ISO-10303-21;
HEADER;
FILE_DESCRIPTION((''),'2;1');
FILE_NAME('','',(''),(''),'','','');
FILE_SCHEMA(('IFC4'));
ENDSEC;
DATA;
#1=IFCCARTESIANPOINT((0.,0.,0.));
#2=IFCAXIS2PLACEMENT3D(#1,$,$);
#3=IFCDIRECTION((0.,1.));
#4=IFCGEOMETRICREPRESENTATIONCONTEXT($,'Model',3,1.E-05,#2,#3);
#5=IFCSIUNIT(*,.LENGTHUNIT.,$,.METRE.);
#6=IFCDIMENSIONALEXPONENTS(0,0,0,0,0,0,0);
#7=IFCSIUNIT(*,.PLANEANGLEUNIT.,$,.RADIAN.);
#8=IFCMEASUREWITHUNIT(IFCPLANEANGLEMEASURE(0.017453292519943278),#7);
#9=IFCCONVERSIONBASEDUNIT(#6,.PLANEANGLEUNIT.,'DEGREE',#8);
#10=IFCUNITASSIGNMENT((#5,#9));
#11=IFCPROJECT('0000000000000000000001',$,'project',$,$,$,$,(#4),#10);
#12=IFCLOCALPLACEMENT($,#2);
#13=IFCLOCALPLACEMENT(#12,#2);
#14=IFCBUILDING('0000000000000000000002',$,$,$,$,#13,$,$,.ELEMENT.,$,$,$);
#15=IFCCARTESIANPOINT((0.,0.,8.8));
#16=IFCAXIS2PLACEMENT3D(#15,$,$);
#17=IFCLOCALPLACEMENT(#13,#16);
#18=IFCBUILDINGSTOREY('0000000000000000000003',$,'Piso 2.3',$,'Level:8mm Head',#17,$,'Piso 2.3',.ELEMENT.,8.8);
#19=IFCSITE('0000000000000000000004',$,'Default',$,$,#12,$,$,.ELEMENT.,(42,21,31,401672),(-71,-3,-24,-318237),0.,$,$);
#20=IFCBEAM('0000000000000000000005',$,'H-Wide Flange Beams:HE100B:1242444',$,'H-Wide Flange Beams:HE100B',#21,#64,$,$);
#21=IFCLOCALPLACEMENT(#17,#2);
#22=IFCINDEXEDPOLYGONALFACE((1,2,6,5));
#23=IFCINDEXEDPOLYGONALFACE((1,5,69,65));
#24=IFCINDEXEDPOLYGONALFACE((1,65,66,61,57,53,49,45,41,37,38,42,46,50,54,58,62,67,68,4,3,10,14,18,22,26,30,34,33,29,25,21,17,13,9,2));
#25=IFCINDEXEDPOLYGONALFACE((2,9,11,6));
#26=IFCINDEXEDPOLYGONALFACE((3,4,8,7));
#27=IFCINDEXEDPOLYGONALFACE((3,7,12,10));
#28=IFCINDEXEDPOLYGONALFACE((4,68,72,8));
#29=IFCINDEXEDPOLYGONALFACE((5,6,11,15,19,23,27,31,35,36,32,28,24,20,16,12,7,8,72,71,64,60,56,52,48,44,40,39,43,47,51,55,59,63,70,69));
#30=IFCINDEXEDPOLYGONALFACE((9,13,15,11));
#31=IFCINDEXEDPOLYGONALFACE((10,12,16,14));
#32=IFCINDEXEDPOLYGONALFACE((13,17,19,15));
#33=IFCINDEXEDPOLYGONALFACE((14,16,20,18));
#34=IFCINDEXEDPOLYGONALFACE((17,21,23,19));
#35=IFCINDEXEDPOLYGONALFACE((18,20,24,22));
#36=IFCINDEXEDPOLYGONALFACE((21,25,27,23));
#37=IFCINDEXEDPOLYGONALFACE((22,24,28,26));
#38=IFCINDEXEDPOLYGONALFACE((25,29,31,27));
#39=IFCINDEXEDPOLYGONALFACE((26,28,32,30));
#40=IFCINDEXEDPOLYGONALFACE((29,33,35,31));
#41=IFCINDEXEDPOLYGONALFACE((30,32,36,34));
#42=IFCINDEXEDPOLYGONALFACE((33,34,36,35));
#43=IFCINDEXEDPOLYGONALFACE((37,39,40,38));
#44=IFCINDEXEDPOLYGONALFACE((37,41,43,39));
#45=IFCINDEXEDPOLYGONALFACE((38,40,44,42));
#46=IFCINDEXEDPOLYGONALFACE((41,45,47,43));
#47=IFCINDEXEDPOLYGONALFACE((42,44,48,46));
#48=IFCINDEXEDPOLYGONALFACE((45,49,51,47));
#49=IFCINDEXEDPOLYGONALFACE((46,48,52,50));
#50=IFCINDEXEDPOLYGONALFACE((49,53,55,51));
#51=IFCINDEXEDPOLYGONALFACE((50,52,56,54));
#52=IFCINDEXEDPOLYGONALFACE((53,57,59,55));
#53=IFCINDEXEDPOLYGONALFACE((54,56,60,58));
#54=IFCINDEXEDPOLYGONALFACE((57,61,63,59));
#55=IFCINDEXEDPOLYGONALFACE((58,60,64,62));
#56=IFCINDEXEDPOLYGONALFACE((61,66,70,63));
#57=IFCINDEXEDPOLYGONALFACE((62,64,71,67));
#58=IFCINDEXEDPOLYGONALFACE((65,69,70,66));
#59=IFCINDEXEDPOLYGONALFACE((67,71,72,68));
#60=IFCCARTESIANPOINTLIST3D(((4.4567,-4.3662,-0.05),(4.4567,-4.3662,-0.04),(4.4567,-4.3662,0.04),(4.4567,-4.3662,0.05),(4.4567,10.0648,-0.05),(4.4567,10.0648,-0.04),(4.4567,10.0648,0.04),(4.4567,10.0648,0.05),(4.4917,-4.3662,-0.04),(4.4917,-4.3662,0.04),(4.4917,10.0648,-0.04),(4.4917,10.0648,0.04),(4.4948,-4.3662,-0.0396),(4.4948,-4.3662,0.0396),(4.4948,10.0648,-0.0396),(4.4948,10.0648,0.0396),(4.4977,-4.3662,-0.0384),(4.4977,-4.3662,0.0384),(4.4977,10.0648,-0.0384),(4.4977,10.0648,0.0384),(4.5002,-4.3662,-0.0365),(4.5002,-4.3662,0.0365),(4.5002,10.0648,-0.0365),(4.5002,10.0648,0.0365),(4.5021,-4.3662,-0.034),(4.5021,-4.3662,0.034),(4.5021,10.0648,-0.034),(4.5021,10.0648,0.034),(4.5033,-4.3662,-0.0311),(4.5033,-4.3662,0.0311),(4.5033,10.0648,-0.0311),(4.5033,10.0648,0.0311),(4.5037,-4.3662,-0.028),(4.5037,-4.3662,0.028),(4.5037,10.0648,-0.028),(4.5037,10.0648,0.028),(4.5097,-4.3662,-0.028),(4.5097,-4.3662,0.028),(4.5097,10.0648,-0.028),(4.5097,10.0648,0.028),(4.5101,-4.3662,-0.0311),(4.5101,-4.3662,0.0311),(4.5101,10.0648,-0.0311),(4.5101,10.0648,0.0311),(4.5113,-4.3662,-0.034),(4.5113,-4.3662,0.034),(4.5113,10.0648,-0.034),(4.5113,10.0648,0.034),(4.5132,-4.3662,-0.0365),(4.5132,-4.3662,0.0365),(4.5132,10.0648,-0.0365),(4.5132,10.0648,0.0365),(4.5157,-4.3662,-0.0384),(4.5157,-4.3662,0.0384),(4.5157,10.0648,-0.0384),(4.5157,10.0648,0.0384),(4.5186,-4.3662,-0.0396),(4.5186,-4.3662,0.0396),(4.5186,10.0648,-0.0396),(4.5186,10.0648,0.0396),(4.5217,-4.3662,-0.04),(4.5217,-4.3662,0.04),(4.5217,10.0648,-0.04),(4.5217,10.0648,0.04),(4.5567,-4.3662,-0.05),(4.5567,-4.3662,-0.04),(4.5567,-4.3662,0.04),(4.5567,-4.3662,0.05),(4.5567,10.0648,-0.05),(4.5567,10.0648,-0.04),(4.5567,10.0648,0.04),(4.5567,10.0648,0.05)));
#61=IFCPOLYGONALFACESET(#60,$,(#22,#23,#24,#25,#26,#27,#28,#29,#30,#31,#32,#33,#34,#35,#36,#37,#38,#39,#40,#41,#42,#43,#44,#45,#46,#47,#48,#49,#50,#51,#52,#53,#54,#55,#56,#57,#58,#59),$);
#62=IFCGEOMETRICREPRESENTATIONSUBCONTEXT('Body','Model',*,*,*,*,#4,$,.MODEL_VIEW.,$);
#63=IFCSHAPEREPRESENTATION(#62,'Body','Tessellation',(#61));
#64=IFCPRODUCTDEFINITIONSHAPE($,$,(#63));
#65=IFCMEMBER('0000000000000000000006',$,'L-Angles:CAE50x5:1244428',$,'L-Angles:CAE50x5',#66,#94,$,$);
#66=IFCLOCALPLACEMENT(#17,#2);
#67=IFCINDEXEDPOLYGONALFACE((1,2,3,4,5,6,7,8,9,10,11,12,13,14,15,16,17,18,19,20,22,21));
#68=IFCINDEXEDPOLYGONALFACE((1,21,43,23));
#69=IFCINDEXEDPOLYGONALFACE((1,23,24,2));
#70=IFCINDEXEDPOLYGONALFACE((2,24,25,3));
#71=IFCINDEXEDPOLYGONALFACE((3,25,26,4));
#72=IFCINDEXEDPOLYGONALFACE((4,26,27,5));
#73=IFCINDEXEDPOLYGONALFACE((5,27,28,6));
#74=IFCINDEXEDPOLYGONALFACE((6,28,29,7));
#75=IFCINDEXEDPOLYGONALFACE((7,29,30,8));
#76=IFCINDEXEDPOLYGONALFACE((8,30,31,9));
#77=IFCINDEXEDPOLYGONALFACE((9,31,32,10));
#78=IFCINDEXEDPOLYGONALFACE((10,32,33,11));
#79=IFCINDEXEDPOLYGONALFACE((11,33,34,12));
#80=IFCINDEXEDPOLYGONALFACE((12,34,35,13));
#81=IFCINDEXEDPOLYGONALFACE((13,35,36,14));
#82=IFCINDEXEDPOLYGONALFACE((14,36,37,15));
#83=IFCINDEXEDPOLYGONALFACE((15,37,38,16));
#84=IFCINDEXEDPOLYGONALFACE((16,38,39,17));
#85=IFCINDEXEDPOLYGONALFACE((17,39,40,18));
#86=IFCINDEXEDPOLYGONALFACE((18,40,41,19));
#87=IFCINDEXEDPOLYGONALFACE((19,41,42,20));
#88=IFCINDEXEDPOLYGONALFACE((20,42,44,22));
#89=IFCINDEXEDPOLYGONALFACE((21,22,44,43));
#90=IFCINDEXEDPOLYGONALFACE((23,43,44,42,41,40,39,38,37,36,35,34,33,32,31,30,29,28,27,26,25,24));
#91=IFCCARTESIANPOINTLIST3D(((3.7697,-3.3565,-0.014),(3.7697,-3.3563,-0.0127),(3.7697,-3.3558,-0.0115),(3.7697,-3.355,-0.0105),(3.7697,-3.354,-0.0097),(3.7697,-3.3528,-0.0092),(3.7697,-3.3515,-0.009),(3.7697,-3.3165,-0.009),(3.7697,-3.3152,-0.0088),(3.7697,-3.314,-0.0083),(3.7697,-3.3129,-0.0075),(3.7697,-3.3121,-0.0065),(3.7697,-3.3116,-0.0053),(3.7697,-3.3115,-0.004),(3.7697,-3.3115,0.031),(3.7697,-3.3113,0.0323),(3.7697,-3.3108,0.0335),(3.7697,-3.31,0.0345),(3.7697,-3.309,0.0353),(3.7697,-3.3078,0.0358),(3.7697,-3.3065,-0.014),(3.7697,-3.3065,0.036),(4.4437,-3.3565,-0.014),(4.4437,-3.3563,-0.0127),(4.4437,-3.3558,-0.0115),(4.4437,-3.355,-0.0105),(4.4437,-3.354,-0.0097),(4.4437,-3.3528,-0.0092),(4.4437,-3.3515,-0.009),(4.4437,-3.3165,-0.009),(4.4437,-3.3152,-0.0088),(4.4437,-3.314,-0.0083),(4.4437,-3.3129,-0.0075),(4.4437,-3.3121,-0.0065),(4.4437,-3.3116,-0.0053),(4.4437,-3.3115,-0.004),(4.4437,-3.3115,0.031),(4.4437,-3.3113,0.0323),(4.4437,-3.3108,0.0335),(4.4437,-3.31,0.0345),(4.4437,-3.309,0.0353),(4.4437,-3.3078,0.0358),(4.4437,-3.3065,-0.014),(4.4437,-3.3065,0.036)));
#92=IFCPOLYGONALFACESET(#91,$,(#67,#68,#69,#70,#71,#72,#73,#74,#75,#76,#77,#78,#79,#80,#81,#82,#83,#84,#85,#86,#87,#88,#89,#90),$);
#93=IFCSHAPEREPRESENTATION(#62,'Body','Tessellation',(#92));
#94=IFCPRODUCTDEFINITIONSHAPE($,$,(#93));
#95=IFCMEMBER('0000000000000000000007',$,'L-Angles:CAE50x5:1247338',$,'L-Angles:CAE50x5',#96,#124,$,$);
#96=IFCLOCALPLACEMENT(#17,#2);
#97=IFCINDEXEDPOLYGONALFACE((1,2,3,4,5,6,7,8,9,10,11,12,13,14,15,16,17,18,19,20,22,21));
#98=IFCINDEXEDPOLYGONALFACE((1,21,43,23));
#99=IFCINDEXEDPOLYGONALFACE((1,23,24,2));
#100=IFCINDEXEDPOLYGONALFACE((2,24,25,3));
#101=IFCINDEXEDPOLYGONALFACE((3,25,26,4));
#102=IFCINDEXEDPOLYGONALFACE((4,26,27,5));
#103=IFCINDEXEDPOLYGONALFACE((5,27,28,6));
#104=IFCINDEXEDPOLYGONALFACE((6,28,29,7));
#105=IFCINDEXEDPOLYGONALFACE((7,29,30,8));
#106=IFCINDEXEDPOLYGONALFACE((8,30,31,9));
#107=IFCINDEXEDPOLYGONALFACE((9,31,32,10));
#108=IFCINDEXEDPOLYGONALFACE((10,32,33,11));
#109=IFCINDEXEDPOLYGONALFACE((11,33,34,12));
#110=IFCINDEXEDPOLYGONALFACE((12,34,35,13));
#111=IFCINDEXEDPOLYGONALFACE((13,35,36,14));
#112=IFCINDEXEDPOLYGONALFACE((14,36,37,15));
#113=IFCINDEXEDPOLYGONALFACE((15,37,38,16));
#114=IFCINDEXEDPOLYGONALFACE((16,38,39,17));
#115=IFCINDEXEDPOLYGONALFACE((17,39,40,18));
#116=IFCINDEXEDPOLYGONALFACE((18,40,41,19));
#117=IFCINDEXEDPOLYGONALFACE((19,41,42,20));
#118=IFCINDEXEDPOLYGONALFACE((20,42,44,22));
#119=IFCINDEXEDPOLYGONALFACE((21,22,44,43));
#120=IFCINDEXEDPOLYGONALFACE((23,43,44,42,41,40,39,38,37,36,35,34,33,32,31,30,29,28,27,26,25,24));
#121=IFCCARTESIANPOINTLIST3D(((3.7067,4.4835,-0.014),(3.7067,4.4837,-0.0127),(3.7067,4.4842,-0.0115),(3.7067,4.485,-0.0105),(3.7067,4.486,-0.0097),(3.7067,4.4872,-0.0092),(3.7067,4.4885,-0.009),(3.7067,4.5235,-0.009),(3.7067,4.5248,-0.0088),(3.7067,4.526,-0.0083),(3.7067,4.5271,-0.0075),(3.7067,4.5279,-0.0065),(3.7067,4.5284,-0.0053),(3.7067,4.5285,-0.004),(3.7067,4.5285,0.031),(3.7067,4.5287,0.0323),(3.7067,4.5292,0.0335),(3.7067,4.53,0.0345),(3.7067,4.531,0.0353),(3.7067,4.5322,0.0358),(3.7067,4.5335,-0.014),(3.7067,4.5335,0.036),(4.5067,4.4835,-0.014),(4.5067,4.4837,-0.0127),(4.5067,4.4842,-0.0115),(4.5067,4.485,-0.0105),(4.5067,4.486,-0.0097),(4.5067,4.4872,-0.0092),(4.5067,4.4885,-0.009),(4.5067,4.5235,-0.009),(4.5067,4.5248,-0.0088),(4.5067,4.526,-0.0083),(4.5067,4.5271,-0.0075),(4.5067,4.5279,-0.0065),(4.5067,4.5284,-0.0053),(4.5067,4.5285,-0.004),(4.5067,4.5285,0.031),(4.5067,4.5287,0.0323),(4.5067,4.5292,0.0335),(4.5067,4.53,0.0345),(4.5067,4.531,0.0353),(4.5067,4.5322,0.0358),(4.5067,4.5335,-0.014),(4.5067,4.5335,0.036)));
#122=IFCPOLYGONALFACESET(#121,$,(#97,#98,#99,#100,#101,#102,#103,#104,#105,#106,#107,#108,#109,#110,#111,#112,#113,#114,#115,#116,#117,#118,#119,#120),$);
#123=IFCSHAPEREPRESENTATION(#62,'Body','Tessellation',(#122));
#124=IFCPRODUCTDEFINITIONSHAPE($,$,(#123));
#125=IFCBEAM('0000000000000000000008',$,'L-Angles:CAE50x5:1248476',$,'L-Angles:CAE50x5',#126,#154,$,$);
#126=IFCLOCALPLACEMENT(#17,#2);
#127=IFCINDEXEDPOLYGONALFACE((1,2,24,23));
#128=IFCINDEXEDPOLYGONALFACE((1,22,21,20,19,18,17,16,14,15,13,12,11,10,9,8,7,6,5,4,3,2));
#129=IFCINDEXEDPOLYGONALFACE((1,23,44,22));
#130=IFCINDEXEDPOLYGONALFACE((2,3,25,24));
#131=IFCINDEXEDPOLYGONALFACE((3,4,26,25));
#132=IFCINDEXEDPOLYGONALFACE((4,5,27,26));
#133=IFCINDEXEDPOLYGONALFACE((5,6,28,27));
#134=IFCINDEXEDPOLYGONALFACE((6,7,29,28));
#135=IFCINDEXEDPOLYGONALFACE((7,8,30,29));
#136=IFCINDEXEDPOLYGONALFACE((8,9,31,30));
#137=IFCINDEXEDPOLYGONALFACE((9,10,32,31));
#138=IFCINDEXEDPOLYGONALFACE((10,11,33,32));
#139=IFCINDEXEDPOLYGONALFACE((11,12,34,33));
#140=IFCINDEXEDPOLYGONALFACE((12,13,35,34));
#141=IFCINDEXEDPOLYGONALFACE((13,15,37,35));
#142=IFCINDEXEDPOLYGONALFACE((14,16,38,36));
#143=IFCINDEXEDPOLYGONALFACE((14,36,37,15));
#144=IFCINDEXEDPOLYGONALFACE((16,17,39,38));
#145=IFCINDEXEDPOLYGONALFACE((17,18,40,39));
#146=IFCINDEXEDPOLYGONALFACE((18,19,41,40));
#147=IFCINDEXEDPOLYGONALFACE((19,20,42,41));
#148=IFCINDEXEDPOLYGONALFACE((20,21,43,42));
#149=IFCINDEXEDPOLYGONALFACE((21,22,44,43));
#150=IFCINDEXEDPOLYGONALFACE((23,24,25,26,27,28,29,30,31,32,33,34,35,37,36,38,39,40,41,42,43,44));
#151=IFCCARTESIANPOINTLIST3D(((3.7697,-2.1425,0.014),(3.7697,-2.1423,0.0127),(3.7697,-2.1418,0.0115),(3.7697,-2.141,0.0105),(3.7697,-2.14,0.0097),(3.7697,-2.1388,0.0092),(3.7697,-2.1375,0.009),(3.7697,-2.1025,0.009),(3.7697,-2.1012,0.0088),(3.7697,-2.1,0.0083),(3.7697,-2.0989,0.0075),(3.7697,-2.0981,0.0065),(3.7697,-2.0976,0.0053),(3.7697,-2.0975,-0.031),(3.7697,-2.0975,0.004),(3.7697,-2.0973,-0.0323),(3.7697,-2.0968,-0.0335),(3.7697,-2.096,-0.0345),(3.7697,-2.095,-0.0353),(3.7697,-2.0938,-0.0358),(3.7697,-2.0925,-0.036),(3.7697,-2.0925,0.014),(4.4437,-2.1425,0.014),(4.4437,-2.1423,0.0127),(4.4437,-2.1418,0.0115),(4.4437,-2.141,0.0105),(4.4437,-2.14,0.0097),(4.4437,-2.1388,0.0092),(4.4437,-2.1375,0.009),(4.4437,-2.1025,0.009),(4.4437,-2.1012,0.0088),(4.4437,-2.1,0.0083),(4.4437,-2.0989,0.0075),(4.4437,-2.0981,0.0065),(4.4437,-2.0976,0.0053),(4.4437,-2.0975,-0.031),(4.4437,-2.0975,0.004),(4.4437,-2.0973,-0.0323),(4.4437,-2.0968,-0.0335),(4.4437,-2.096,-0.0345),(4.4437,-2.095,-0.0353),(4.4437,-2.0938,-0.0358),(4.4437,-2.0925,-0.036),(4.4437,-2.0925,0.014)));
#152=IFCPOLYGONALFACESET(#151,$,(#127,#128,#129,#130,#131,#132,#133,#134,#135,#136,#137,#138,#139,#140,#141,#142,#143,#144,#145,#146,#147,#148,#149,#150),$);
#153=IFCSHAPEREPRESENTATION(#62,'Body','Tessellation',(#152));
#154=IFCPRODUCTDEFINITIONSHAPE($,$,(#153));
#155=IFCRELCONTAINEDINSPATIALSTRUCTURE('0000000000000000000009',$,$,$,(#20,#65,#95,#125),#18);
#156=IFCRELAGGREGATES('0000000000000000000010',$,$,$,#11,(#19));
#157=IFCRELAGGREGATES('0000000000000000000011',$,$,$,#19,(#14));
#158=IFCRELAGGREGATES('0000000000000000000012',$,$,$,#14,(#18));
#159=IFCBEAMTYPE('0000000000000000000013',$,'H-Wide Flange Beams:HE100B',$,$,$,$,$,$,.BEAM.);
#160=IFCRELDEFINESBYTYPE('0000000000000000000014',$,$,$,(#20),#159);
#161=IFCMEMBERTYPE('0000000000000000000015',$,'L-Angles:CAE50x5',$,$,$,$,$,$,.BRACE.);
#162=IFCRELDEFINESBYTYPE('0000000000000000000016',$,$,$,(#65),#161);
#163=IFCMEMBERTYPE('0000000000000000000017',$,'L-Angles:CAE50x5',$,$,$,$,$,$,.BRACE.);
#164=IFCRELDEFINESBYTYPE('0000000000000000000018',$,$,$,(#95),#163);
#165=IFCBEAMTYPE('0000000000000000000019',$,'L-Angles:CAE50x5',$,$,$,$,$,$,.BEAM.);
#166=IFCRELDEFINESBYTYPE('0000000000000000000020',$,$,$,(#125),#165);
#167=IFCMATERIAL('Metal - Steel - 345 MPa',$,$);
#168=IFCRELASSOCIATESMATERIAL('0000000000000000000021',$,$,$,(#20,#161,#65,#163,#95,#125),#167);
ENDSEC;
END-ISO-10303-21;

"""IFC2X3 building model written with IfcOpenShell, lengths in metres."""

from ifc_helpers import new_model, entity, si_unit, converted_unit, direction, frame, frame_2d, origin, place, context, subcontext, project, spatial, polyline, circle_curve, parameter, trimmed, segment, composite_curve, i_section, outline, extrude, source, transform, mapped, material, type_object, type_shapes, element, save


model = new_model("IFC2X3")

# Units and contexts
model_context = context("Model", 3, precision=1e-05, world=origin(), true_north=direction((0.0, 1.0)))
body_context = subcontext(model_context, "Body", "Model", "MODEL_VIEW")
ifc_project = project(units=[si_unit("LENGTHUNIT", "METRE"), converted_unit("PLANEANGLEUNIT", "DEGREE", entity("IfcPlaneAngleMeasure", 0.017453292519943278), si_unit("PLANEANGLEUNIT", "RADIAN"), dimensions=[0, 0, 0, 0, 0, 0, 0])], contexts=[model_context])

# Site, building, storey
site_placement = place(None, origin())
site = spatial("IfcSite", under=ifc_project, at=site_placement, Name="Default", CompositionType="ELEMENT", RefLatitude=(42, 21, 31, 401672), RefLongitude=(-71, -3, -24, -318237), RefElevation=0.0)
building_placement = place(site_placement, origin())
building = spatial("IfcBuilding", under=site, at=building_placement, CompositionType="ELEMENT")
storey_placement = place(building_placement, frame((0.0, 0.0, 8.8)))
storey = spatial("IfcBuildingStorey", under=building, at=storey_placement, Name="Piso 2.3", ObjectType="Level:8mm Head", LongName="Piso 2.3", CompositionType="ELEMENT", Elevation=8.8)

# Beam
ifc_material_1 = material(Name="Metal - Steel - 345 MPa")
beam_type_1 = type_object("IfcBeamType", Name="H-Wide Flange Beams:HE100B", PredefinedType="BEAM")
beam_1_placement = place(storey_placement, frame((4.5067, -3.7965, 0.0), z_axis=(0.0, 0.0, 1.0), x_axis=(0.0, 1.0, 0.0)))
element("IfcBeam", 1, at=beam_1_placement, inside=storey, type_object=beam_type_1, material=ifc_material_1, Name="H-Wide Flange Beams:HE100B:1242444", ObjectType="H-Wide Flange Beams:HE100B", context=body_context, shape_type="SweptSolid", body=[
    extrude(i_section(OverallWidth=0.1, OverallDepth=0.1, WebThickness=0.006, FlangeThickness=0.01, FilletRadius=0.012, at=frame_2d((0.0, 0.0), x_axis=(0.0, 1.0))), frame((-0.5697, 0.0, 0.0), z_axis=(1.0, 0.0, 0.0), x_axis=(0.0, 0.0, -1.0)), (0.0, 0.0, 1.0), 14.431),
])

# Members
member_type_1 = type_object("IfcMemberType", Name="L-Angles:CAE50x5", PredefinedType="BRACE", material=ifc_material_1)
shared_shape_1 = source(origin(), body_context, "Body", "SweptSolid", [
    extrude(outline(composite_curve([segment(polyline([(-0.0164, -0.0164), (0.0336, -0.0164)]), True, "CONTINUOUS"), segment(trimmed(circle_curve(frame_2d((0.0286, -0.0164), x_axis=(1.0, 0.0)), 0.005), [parameter(0.0)], [parameter(90.0)], True, "PARAMETER"), True, "CONTINUOUS"), segment(polyline([(0.0286, -0.0114), (-0.0064, -0.0114)]), True, "CONTINUOUS"), segment(trimmed(circle_curve(frame_2d((-0.0064, -0.0064), x_axis=(1.0, 0.0)), 0.005), [parameter(180.0)], [parameter(270.0)], True, "PARAMETER"), False, "CONTINUOUS"), segment(polyline([(-0.0114, -0.0064), (-0.0114, 0.0286)]), True, "CONTINUOUS"), segment(trimmed(circle_curve(frame_2d((-0.0164, 0.0286), x_axis=(1.0, 0.0)), 0.005), [parameter(0.0)], [parameter(90.0)], True, "PARAMETER"), True, "CONTINUOUS"), segment(polyline([(-0.0164, 0.0336), (-0.0164, -0.0164)]), True, "CONTINUOUS")], self_intersect=False)), frame((-0.337, -0.0024, -0.0024), z_axis=(1.0, 0.0, 0.0), x_axis=(0.0, -1.0, 0.0)), (0.0, 0.0, 1.0), 0.674),
])
type_shapes(member_type_1, [shared_shape_1])
member_1_placement = place(storey_placement, frame((4.1067, -3.3205, 0.0), z_axis=(0.0, 1.0, 0.0), x_axis=(1.0, 0.0, 0.0)))
element("IfcMember", 2, at=member_1_placement, inside=storey, type_object=member_type_1, material=ifc_material_1, Name="L-Angles:CAE50x5:1244428", ObjectType="L-Angles:CAE50x5", context=body_context, shape_type="MappedRepresentation", body=[
    mapped(shared_shape_1, transform((0.0, 0.0, 0.0), scale=1.0)),
])
member_type_2 = type_object("IfcMemberType", Name="L-Angles:CAE50x5", PredefinedType="BRACE", material=ifc_material_1)
shared_shape_2 = source(origin(), body_context, "Body", "SweptSolid", [
    extrude(outline(composite_curve([segment(polyline([(-0.0164, -0.0164), (0.0336, -0.0164)]), True, "CONTINUOUS"), segment(trimmed(circle_curve(frame_2d((0.0286, -0.0164), x_axis=(1.0, 0.0)), 0.005), [parameter(0.0)], [parameter(90.0)], True, "PARAMETER"), True, "CONTINUOUS"), segment(polyline([(0.0286, -0.0114), (-0.0064, -0.0114)]), True, "CONTINUOUS"), segment(trimmed(circle_curve(frame_2d((-0.0064, -0.0064), x_axis=(1.0, 0.0)), 0.005), [parameter(180.0)], [parameter(270.0)], True, "PARAMETER"), False, "CONTINUOUS"), segment(polyline([(-0.0114, -0.0064), (-0.0114, 0.0286)]), True, "CONTINUOUS"), segment(trimmed(circle_curve(frame_2d((-0.0164, 0.0286), x_axis=(1.0, 0.0)), 0.005), [parameter(0.0)], [parameter(90.0)], True, "PARAMETER"), True, "CONTINUOUS"), segment(polyline([(-0.0164, 0.0336), (-0.0164, -0.0164)]), True, "CONTINUOUS")], self_intersect=False)), frame((-0.4, -0.0024, -0.0024), z_axis=(1.0, 0.0, 0.0), x_axis=(0.0, -1.0, 0.0)), (0.0, 0.0, 1.0), 0.8),
])
type_shapes(member_type_2, [shared_shape_2])
member_2_placement = place(storey_placement, frame((4.1067, 4.5195, 0.0), z_axis=(0.0, 1.0, 0.0), x_axis=(1.0, 0.0, 0.0)))
element("IfcMember", 3, at=member_2_placement, inside=storey, type_object=member_type_2, material=ifc_material_1, Name="L-Angles:CAE50x5:1247338", ObjectType="L-Angles:CAE50x5", context=body_context, shape_type="MappedRepresentation", body=[
    mapped(shared_shape_2, transform((0.0, 0.0, 0.0), scale=1.0)),
])

# Beam
beam_type_2 = type_object("IfcBeamType", Name="L-Angles:CAE50x5", PredefinedType="BEAM")
beam_2_placement = place(storey_placement, frame((3.7067, -2.1065, 0.0)))
element("IfcBeam", 4, at=beam_2_placement, inside=storey, type_object=beam_type_2, material=ifc_material_1, Name="L-Angles:CAE50x5:1248476", ObjectType="L-Angles:CAE50x5", context=body_context, shape_type="SweptSolid", body=[
    extrude(outline(composite_curve([segment(polyline([(-0.0336, -0.0164), (0.0164, -0.0164)]), True, "CONTINUOUS"), segment(polyline([(0.0164, -0.0164), (0.0164, 0.0336)]), True, "CONTINUOUS"), segment(trimmed(circle_curve(frame_2d((0.0164, 0.0286), x_axis=(0.0, 1.0)), 0.005), [parameter(0.0)], [parameter(90.0)], True, "PARAMETER"), True, "CONTINUOUS"), segment(polyline([(0.0114, 0.0286), (0.0114, -0.0064)]), True, "CONTINUOUS"), segment(trimmed(circle_curve(frame_2d((0.0064, -0.0064), x_axis=(1.0, 0.0)), 0.005), [parameter(270.0)], [parameter(0.0)], True, "PARAMETER"), False, "CONTINUOUS"), segment(polyline([(0.0064, -0.0114), (-0.0286, -0.0114)]), True, "CONTINUOUS"), segment(trimmed(circle_curve(frame_2d((-0.0286, -0.0164), x_axis=(0.0, 1.0)), 0.005), [parameter(0.0)], [parameter(90.0)], True, "PARAMETER"), True, "CONTINUOUS")], self_intersect=False)), frame((0.063, -0.0024, -0.0024), z_axis=(1.0, 0.0, 0.0), x_axis=(0.0, 0.0, 1.0)), (0.0, 0.0, 1.0), 0.674),
])

save(model, "model.ifc")
